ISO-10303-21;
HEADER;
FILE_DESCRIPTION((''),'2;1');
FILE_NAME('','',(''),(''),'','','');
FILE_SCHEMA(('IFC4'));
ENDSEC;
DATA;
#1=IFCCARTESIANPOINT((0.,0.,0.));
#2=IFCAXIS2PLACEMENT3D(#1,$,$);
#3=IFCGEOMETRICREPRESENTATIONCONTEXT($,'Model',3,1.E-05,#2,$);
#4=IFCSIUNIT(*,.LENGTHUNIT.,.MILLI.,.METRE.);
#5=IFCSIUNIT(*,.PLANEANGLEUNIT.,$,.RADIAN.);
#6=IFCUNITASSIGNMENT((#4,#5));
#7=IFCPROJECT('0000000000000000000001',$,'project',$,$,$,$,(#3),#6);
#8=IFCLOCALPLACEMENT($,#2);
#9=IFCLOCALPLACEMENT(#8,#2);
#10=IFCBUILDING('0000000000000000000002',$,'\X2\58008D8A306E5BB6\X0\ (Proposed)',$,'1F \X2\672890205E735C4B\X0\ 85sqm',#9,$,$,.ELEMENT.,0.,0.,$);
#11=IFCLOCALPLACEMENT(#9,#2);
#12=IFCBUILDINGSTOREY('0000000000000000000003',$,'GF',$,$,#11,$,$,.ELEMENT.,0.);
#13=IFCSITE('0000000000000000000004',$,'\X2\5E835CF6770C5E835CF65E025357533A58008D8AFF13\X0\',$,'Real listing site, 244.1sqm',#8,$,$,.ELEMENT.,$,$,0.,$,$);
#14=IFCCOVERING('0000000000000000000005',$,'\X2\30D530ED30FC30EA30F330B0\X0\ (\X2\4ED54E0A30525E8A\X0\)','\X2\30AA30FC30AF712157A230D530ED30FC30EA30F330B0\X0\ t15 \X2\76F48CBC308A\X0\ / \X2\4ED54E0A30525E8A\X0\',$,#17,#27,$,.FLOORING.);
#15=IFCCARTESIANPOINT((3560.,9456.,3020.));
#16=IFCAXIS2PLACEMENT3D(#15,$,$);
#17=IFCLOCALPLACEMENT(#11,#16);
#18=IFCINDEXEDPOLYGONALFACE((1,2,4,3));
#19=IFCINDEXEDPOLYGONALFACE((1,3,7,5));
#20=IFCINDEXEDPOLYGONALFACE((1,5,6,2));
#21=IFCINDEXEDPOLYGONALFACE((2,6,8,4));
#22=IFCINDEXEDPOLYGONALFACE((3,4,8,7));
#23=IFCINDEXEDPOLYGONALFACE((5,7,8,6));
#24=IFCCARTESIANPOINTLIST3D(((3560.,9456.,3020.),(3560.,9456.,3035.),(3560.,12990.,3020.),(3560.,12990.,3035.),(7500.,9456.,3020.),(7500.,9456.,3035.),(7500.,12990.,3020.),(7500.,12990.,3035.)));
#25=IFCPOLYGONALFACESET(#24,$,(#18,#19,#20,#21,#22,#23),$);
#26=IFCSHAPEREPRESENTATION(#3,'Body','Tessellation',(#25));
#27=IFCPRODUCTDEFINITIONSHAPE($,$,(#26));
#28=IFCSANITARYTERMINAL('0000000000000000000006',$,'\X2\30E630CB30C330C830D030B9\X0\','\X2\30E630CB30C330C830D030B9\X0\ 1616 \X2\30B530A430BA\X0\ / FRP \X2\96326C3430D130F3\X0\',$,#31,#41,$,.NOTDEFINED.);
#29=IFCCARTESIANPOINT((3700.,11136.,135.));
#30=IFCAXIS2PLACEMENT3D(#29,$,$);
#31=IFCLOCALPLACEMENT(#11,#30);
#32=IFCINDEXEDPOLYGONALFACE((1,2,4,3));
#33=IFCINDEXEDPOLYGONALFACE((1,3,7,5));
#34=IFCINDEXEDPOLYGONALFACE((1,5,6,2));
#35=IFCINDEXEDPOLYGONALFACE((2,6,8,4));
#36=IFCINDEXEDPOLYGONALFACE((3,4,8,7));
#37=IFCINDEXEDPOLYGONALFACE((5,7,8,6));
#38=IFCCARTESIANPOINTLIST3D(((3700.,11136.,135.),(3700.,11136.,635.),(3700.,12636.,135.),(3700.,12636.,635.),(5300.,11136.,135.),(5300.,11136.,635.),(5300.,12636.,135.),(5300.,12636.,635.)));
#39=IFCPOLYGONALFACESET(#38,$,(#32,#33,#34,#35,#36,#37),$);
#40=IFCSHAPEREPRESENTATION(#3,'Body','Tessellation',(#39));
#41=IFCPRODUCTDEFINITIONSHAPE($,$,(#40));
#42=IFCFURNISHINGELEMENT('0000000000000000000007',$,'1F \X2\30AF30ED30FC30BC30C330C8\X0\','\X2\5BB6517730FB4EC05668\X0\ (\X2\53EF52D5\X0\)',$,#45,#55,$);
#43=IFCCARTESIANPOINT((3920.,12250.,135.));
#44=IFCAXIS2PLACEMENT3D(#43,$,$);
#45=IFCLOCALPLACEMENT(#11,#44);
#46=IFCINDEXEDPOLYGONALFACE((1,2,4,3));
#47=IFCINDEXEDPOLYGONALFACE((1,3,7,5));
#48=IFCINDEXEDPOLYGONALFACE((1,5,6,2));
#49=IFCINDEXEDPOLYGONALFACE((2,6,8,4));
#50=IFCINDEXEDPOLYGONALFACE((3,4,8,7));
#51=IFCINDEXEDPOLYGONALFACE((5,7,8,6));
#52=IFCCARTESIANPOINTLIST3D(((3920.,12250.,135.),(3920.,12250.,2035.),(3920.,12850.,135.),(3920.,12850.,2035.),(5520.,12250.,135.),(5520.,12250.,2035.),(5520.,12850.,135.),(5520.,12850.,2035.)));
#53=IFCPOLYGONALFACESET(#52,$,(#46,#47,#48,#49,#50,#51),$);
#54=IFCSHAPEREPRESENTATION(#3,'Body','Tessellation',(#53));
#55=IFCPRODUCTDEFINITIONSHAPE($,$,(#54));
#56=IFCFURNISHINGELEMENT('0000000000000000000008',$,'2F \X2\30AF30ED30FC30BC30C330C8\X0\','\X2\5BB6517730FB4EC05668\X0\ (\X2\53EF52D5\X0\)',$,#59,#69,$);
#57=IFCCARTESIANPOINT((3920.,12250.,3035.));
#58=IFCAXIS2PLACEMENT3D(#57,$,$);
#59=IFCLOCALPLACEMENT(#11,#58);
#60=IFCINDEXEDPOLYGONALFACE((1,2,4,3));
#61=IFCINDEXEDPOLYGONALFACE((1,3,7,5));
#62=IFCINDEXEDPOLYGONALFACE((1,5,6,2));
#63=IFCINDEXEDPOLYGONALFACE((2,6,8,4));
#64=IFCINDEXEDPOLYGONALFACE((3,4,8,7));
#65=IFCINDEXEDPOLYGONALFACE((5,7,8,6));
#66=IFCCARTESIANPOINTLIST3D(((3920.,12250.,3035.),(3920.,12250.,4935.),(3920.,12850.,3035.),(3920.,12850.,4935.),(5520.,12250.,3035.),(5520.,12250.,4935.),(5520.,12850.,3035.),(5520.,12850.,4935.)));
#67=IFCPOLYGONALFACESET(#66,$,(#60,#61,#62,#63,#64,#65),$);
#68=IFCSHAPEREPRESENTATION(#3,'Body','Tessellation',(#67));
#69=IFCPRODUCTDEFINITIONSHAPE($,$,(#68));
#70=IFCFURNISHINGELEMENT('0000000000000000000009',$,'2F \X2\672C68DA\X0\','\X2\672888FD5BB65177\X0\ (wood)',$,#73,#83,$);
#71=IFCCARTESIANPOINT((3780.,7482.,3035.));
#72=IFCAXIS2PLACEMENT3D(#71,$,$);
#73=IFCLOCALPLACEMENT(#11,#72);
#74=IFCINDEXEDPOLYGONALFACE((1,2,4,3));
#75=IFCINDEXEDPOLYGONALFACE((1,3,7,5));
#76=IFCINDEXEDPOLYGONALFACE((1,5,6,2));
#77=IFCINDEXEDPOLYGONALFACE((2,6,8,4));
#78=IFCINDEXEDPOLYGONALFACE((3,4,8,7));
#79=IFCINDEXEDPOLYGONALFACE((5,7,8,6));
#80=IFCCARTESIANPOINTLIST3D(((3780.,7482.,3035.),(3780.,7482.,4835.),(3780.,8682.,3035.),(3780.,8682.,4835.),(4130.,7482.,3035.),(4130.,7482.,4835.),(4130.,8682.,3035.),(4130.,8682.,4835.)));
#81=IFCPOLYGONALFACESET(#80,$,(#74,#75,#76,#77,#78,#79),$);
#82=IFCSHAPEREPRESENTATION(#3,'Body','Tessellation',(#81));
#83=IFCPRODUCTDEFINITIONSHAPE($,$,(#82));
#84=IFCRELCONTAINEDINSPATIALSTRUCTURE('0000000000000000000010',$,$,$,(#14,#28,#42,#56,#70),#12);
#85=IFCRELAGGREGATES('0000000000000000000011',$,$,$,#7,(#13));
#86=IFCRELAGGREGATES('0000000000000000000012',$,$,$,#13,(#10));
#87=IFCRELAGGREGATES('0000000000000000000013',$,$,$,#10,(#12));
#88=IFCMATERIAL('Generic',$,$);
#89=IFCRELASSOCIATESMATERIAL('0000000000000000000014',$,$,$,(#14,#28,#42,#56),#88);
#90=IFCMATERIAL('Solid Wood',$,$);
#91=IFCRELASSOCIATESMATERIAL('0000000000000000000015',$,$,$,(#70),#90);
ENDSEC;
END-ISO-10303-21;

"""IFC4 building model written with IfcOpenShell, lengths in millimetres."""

from ifc_helpers import new_model, si_unit, frame, frame_2d, origin, place, context, project, spatial, rectangle, extrude, material, element, save


model = new_model("IFC4")

# Units and contexts
model_context = context("Model", 3, precision=1e-05, world=origin())
ifc_project = project(units=[si_unit("LENGTHUNIT", "METRE", prefix="MILLI"), si_unit("PLANEANGLEUNIT", "RADIAN")], contexts=[model_context])

# Site, building, storey
site_placement = place(None, origin())
site = spatial("IfcSite", under=ifc_project, at=site_placement, Name="広島県広島市南区堀越３", ObjectType="Real listing site, 244.1sqm", CompositionType="ELEMENT", RefElevation=0.0)
building_placement = place(site_placement, origin())
building = spatial("IfcBuilding", under=site, at=building_placement, Name="堀越の家 (Proposed)", ObjectType="1F 木造平屋 85sqm", CompositionType="ELEMENT", ElevationOfRefHeight=0.0, ElevationOfTerrain=0.0)
storey_placement = place(building_placement, origin())
storey = spatial("IfcBuildingStorey", under=building, at=storey_placement, Name="GF", CompositionType="ELEMENT", Elevation=0.0)

# Shared definitions
ifc_material_1 = material(Name="Solid Wood")

# Covering
ifc_material_2 = material(Name="Generic")
covering_1_placement = place(storey_placement, frame((3560.0, 9456.0, 3020.0)))
element("IfcCovering", 1, at=covering_1_placement, inside=storey, material=ifc_material_2, Name="フローリング (仕上げ床)", Description="オーク無垢フローリング t15 直貼り / 仕上げ床", PredefinedType="FLOORING", context=model_context, shape_type="SweptSolid", body=[
    extrude(rectangle(XDim=3940.0, YDim=3534.0, at=frame_2d((1970.0, 1767.0))), frame((3560.0, 9456.0, 3020.0)), (0.0, 0.0, 1.0), 15.0),
])

# Sanitary terminal
sanitary_terminal_placement = place(storey_placement, frame((3700.0, 11136.0, 135.0)))
element("IfcSanitaryTerminal", 2, at=sanitary_terminal_placement, inside=storey, material=ifc_material_2, Name="ユニットバス", Description="ユニットバス 1616 サイズ / FRP 防水パン", PredefinedType="NOTDEFINED", context=model_context, shape_type="SweptSolid", body=[
    extrude(rectangle(XDim=1600.0, YDim=1500.0, at=frame_2d((800.0, 750.0))), frame((3700.0, 11136.0, 135.0)), (0.0, 0.0, 1.0), 500.0),
])

# Furnishing elements
furnishing_1_placement = place(storey_placement, frame((3920.0, 12250.0, 135.0)))
element("IfcFurnishingElement", 3, at=furnishing_1_placement, inside=storey, material=ifc_material_2, Name="1F クローゼット", Description="家具・什器 (可動)", context=model_context, shape_type="SweptSolid", body=[
    extrude(rectangle(XDim=1600.0, YDim=600.0, at=frame_2d((800.0, 300.0))), frame((3920.0, 12250.0, 135.0)), (0.0, 0.0, 1.0), 1900.0),
])
furnishing_2_placement = place(storey_placement, frame((3920.0, 12250.0, 3035.0)))
element("IfcFurnishingElement", 4, at=furnishing_2_placement, inside=storey, material=ifc_material_2, Name="2F クローゼット", Description="家具・什器 (可動)", context=model_context, shape_type="SweptSolid", body=[
    extrude(rectangle(XDim=1600.0, YDim=600.0, at=frame_2d((800.0, 300.0))), frame((3920.0, 12250.0, 3035.0)), (0.0, 0.0, 1.0), 1900.0),
])
furnishing_3_placement = place(storey_placement, frame((3780.0, 7482.0, 3035.0)))
element("IfcFurnishingElement", 5, at=furnishing_3_placement, inside=storey, material=ifc_material_1, Name="2F 本棚", Description="木製家具 (wood)", context=model_context, shape_type="SweptSolid", body=[
    extrude(rectangle(XDim=350.0, YDim=1200.0, at=frame_2d((175.0, 600.0))), frame((3780.0, 7482.0, 3035.0)), (0.0, 0.0, 1.0), 1800.0),
])

save(model, "model.ifc")
